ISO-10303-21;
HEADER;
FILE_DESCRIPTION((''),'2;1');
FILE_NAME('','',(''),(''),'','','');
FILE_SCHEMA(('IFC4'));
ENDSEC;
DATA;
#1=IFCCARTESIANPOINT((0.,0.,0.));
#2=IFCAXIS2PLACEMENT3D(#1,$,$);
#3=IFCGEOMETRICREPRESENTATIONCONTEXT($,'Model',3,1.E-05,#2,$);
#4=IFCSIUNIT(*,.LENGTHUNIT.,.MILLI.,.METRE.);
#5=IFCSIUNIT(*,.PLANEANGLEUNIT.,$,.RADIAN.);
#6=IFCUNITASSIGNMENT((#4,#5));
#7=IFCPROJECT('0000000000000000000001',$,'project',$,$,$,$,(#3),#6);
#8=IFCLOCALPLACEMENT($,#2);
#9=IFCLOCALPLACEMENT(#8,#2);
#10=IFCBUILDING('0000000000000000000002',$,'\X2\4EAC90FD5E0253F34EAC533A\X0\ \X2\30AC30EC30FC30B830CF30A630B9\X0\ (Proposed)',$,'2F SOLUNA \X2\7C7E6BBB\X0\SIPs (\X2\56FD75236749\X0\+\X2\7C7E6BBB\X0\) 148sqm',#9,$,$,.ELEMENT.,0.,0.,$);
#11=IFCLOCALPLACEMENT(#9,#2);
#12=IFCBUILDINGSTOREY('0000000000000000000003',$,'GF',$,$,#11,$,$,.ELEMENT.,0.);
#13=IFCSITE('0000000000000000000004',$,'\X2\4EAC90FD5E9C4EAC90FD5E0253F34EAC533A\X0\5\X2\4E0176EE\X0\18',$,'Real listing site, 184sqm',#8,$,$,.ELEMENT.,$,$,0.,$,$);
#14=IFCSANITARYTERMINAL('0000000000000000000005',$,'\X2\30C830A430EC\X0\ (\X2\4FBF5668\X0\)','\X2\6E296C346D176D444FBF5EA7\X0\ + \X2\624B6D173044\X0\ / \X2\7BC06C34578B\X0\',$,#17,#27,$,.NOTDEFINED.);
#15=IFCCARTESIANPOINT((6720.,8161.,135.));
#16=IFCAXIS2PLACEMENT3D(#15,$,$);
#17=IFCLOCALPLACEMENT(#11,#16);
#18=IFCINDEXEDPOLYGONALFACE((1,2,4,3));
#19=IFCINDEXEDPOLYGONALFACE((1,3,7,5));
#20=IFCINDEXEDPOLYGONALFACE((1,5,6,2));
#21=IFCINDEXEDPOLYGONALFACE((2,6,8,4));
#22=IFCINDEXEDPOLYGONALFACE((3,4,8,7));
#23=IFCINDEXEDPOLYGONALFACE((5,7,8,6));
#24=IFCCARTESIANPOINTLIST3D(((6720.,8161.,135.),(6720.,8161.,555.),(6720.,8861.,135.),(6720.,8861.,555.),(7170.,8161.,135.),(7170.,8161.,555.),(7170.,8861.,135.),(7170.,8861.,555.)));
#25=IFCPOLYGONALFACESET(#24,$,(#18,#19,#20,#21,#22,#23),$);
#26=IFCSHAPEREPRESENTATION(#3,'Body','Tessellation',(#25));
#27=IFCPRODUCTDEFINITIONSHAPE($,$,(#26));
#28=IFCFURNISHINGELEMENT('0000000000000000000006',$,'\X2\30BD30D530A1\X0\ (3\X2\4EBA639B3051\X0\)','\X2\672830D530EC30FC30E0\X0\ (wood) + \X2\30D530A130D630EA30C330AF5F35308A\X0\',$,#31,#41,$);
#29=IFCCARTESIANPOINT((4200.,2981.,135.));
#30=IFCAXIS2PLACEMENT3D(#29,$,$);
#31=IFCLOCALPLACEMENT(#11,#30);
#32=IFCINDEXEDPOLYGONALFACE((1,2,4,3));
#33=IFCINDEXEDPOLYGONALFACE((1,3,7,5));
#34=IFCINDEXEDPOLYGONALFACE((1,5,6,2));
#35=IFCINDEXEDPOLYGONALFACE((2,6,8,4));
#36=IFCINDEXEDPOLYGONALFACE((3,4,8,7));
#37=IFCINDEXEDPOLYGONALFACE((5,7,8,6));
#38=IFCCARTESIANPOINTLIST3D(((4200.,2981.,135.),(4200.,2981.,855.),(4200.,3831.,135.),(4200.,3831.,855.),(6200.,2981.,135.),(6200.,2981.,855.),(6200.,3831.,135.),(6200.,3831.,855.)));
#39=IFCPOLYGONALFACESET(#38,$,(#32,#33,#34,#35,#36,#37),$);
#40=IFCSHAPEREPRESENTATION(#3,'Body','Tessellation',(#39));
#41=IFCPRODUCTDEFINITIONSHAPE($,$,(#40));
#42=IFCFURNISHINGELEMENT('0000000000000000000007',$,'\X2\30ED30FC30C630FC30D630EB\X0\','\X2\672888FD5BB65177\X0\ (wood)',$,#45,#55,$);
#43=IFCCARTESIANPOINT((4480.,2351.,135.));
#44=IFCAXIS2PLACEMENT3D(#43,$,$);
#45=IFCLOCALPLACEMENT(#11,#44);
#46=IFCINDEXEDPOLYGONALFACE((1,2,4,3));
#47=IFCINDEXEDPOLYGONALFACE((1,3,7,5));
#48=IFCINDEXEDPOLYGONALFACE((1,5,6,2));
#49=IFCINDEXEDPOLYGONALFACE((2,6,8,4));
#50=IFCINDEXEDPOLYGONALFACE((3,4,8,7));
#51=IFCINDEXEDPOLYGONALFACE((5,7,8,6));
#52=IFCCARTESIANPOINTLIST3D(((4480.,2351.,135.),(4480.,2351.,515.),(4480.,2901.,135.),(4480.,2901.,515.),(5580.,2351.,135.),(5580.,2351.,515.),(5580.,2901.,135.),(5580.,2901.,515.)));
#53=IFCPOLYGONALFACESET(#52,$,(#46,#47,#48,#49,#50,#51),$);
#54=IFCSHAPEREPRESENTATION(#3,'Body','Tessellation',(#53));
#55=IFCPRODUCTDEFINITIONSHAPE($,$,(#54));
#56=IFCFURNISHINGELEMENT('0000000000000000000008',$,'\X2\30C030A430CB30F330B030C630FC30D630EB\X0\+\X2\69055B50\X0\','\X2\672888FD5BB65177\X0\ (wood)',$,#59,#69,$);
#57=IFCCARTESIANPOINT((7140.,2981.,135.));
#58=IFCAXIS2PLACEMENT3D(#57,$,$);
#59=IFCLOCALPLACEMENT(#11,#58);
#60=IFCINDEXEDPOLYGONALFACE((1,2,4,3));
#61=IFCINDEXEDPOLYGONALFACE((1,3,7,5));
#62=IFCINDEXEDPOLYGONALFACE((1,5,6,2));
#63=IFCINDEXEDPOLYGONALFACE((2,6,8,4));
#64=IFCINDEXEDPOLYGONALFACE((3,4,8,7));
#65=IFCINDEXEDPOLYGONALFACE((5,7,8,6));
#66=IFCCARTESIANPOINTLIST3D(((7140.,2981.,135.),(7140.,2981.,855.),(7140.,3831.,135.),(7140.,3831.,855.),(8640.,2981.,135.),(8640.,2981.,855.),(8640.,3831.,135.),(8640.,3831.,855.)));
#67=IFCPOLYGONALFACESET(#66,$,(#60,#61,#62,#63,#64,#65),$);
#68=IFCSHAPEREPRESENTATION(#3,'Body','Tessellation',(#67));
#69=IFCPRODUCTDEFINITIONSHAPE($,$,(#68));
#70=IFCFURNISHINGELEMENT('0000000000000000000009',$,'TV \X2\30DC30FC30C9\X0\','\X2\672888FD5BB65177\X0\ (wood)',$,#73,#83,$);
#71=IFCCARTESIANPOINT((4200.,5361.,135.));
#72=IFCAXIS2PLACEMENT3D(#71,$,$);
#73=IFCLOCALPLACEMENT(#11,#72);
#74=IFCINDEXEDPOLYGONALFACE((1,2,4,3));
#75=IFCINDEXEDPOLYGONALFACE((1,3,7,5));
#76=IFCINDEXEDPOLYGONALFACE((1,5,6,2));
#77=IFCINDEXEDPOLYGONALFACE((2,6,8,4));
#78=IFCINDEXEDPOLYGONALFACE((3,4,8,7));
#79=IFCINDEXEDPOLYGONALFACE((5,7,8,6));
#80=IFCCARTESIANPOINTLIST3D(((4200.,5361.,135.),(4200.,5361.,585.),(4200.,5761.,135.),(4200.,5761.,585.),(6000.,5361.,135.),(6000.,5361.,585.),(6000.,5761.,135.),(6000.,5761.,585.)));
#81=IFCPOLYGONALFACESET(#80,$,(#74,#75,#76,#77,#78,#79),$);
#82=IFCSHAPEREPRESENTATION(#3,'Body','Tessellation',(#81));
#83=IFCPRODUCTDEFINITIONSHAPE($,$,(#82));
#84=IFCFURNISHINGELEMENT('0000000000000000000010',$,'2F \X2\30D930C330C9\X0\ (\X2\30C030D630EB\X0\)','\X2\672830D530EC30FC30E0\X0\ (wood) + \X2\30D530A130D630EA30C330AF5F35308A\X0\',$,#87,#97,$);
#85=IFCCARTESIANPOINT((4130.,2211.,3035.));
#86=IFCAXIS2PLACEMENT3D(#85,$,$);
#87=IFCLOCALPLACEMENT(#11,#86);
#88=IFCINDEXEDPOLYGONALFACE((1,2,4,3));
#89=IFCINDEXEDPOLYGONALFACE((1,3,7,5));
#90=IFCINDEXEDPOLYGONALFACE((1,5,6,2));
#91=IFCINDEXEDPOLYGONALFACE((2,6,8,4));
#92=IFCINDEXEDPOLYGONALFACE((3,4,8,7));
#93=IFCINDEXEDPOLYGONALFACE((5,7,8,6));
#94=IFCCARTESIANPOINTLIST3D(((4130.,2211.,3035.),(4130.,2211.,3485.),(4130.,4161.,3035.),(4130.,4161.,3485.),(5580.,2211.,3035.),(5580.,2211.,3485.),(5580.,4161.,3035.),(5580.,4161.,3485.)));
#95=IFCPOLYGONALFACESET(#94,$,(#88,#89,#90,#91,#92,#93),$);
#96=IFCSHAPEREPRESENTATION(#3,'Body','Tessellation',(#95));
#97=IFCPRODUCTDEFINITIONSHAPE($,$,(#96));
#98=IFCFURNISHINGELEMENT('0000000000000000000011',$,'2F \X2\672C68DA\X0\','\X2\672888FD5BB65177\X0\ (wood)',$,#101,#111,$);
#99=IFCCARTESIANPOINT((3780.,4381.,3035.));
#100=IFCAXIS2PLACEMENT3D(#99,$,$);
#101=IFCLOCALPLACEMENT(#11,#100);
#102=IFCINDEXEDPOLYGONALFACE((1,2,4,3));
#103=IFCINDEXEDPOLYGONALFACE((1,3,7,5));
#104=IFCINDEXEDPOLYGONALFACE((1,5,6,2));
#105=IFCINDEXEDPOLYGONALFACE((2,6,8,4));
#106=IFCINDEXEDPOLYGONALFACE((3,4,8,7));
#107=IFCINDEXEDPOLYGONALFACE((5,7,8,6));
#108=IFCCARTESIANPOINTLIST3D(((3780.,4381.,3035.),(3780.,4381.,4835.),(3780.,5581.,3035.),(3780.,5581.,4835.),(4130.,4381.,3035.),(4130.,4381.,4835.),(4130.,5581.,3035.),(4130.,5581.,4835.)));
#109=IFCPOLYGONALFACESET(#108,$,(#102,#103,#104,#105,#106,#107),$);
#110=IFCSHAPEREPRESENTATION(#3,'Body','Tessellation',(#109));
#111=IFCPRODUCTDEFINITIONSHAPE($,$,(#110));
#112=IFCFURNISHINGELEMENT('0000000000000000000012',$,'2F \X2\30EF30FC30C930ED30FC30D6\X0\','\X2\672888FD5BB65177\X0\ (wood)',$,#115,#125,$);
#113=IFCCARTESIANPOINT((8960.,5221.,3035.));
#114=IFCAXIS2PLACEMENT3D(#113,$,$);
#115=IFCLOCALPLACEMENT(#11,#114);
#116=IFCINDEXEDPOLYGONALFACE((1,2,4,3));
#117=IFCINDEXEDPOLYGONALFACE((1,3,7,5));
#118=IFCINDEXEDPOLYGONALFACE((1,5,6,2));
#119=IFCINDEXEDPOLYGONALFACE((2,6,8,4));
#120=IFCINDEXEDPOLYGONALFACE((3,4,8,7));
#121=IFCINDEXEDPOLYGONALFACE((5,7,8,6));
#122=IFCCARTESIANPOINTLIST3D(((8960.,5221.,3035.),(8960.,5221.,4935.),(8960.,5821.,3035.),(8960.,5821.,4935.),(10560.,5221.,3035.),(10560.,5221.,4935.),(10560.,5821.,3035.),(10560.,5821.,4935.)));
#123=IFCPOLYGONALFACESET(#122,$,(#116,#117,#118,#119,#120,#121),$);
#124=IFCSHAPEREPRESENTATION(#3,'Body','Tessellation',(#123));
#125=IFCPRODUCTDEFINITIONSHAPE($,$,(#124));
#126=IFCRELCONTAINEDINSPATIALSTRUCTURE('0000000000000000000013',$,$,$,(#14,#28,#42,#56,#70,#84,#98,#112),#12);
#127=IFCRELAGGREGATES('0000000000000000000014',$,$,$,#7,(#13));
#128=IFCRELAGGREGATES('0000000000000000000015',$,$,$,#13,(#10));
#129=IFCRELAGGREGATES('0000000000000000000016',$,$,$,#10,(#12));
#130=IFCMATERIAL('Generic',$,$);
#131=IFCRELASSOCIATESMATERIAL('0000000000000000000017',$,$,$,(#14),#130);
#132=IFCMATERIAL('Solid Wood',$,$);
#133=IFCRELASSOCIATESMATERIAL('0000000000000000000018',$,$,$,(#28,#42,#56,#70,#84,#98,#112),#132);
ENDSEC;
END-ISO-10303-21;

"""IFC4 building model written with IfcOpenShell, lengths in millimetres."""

from ifc_helpers import new_model, si_unit, frame, frame_2d, origin, place, context, project, spatial, rectangle, extrude, material, element, save


model = new_model("IFC4")

# Units and contexts
model_context = context("Model", 3, precision=1e-05, world=origin())
ifc_project = project(units=[si_unit("LENGTHUNIT", "METRE", prefix="MILLI"), si_unit("PLANEANGLEUNIT", "RADIAN")], contexts=[model_context])

# Site, building, storey
site_placement = place(None, origin())
site = spatial("IfcSite", under=ifc_project, at=site_placement, Name="京都府京都市右京区5丁目18", ObjectType="Real listing site, 184sqm", CompositionType="ELEMENT", RefElevation=0.0)
building_placement = place(site_placement, origin())
building = spatial("IfcBuilding", under=site, at=building_placement, Name="京都市右京区 ガレージハウス (Proposed)", ObjectType="2F SOLUNA 籾殻SIPs (国産杉+籾殻) 148sqm", CompositionType="ELEMENT", ElevationOfRefHeight=0.0, ElevationOfTerrain=0.0)
storey_placement = place(building_placement, origin())
storey = spatial("IfcBuildingStorey", under=building, at=storey_placement, Name="GF", CompositionType="ELEMENT", Elevation=0.0)

# Shared definitions
ifc_material_1 = material(Name="Solid Wood")

# Shared definitions
ifc_material_2 = material(Name="Generic")

# Sanitary terminal
sanitary_terminal_1_placement = place(storey_placement, frame((6720.0, 8161.0, 135.0)))
element("IfcSanitaryTerminal", 1, at=sanitary_terminal_1_placement, inside=storey, material=ifc_material_2, Name="トイレ (便器)", Description="温水洗浄便座 + 手洗い / 節水型", PredefinedType="NOTDEFINED", context=model_context, shape_type="SweptSolid", body=[
    extrude(rectangle(XDim=450.0, YDim=700.0, at=frame_2d((225.0, 350.0))), frame((6720.0, 8161.0, 135.0)), (0.0, 0.0, 1.0), 420.0),
])

# Furnishing elements
furnishing_1_placement = place(storey_placement, frame((4200.0, 2981.0, 135.0)))
element("IfcFurnishingElement", 2, at=furnishing_1_placement, inside=storey, material=ifc_material_1, Name="ソファ (3人掛け)", Description="木フレーム (wood) + ファブリック張り", context=model_context, shape_type="SweptSolid", body=[
    extrude(rectangle(XDim=2000.0, YDim=850.0, at=frame_2d((1000.0, 425.0))), frame((4200.0, 2981.0, 135.0)), (0.0, 0.0, 1.0), 720.0),
])
furnishing_2_placement = place(storey_placement, frame((4480.0, 2351.0, 135.0)))
element("IfcFurnishingElement", 3, at=furnishing_2_placement, inside=storey, material=ifc_material_1, Name="ローテーブル", Description="木製家具 (wood)", context=model_context, shape_type="SweptSolid", body=[
    extrude(rectangle(XDim=1100.0, YDim=550.0, at=frame_2d((550.0, 275.0))), frame((4480.0, 2351.0, 135.0)), (0.0, 0.0, 1.0), 380.0),
])
furnishing_3_placement = place(storey_placement, frame((7140.0, 2981.0, 135.0)))
element("IfcFurnishingElement", 4, at=furnishing_3_placement, inside=storey, material=ifc_material_1, Name="ダイニングテーブル+椅子", Description="木製家具 (wood)", context=model_context, shape_type="SweptSolid", body=[
    extrude(rectangle(XDim=1500.0, YDim=850.0, at=frame_2d((750.0, 425.0))), frame((7140.0, 2981.0, 135.0)), (0.0, 0.0, 1.0), 720.0),
])
furnishing_4_placement = place(storey_placement, frame((4200.0, 5361.0, 135.0)))
element("IfcFurnishingElement", 5, at=furnishing_4_placement, inside=storey, material=ifc_material_1, Name="TV ボード", Description="木製家具 (wood)", context=model_context, shape_type="SweptSolid", body=[
    extrude(rectangle(XDim=1800.0, YDim=400.0, at=frame_2d((900.0, 200.0))), frame((4200.0, 5361.0, 135.0)), (0.0, 0.0, 1.0), 450.0),
])
furnishing_5_placement = place(storey_placement, frame((4130.0, 2211.0, 3035.0)))
element("IfcFurnishingElement", 6, at=furnishing_5_placement, inside=storey, material=ifc_material_1, Name="2F ベッド (ダブル)", Description="木フレーム (wood) + ファブリック張り", context=model_context, shape_type="SweptSolid", body=[
    extrude(rectangle(XDim=1450.0, YDim=1950.0, at=frame_2d((725.0, 975.0))), frame((4130.0, 2211.0, 3035.0)), (0.0, 0.0, 1.0), 450.0),
])
furnishing_6_placement = place(storey_placement, frame((3780.0, 4381.0, 3035.0)))
element("IfcFurnishingElement", 7, at=furnishing_6_placement, inside=storey, material=ifc_material_1, Name="2F 本棚", Description="木製家具 (wood)", context=model_context, shape_type="SweptSolid", body=[
    extrude(rectangle(XDim=350.0, YDim=1200.0, at=frame_2d((175.0, 600.0))), frame((3780.0, 4381.0, 3035.0)), (0.0, 0.0, 1.0), 1800.0),
])
furnishing_7_placement = place(storey_placement, frame((8960.0, 5221.0, 3035.0)))
element("IfcFurnishingElement", 8, at=furnishing_7_placement, inside=storey, material=ifc_material_1, Name="2F ワードローブ", Description="木製家具 (wood)", context=model_context, shape_type="SweptSolid", body=[
    extrude(rectangle(XDim=1600.0, YDim=600.0, at=frame_2d((800.0, 300.0))), frame((8960.0, 5221.0, 3035.0)), (0.0, 0.0, 1.0), 1900.0),
])

save(model, "model.ifc")
